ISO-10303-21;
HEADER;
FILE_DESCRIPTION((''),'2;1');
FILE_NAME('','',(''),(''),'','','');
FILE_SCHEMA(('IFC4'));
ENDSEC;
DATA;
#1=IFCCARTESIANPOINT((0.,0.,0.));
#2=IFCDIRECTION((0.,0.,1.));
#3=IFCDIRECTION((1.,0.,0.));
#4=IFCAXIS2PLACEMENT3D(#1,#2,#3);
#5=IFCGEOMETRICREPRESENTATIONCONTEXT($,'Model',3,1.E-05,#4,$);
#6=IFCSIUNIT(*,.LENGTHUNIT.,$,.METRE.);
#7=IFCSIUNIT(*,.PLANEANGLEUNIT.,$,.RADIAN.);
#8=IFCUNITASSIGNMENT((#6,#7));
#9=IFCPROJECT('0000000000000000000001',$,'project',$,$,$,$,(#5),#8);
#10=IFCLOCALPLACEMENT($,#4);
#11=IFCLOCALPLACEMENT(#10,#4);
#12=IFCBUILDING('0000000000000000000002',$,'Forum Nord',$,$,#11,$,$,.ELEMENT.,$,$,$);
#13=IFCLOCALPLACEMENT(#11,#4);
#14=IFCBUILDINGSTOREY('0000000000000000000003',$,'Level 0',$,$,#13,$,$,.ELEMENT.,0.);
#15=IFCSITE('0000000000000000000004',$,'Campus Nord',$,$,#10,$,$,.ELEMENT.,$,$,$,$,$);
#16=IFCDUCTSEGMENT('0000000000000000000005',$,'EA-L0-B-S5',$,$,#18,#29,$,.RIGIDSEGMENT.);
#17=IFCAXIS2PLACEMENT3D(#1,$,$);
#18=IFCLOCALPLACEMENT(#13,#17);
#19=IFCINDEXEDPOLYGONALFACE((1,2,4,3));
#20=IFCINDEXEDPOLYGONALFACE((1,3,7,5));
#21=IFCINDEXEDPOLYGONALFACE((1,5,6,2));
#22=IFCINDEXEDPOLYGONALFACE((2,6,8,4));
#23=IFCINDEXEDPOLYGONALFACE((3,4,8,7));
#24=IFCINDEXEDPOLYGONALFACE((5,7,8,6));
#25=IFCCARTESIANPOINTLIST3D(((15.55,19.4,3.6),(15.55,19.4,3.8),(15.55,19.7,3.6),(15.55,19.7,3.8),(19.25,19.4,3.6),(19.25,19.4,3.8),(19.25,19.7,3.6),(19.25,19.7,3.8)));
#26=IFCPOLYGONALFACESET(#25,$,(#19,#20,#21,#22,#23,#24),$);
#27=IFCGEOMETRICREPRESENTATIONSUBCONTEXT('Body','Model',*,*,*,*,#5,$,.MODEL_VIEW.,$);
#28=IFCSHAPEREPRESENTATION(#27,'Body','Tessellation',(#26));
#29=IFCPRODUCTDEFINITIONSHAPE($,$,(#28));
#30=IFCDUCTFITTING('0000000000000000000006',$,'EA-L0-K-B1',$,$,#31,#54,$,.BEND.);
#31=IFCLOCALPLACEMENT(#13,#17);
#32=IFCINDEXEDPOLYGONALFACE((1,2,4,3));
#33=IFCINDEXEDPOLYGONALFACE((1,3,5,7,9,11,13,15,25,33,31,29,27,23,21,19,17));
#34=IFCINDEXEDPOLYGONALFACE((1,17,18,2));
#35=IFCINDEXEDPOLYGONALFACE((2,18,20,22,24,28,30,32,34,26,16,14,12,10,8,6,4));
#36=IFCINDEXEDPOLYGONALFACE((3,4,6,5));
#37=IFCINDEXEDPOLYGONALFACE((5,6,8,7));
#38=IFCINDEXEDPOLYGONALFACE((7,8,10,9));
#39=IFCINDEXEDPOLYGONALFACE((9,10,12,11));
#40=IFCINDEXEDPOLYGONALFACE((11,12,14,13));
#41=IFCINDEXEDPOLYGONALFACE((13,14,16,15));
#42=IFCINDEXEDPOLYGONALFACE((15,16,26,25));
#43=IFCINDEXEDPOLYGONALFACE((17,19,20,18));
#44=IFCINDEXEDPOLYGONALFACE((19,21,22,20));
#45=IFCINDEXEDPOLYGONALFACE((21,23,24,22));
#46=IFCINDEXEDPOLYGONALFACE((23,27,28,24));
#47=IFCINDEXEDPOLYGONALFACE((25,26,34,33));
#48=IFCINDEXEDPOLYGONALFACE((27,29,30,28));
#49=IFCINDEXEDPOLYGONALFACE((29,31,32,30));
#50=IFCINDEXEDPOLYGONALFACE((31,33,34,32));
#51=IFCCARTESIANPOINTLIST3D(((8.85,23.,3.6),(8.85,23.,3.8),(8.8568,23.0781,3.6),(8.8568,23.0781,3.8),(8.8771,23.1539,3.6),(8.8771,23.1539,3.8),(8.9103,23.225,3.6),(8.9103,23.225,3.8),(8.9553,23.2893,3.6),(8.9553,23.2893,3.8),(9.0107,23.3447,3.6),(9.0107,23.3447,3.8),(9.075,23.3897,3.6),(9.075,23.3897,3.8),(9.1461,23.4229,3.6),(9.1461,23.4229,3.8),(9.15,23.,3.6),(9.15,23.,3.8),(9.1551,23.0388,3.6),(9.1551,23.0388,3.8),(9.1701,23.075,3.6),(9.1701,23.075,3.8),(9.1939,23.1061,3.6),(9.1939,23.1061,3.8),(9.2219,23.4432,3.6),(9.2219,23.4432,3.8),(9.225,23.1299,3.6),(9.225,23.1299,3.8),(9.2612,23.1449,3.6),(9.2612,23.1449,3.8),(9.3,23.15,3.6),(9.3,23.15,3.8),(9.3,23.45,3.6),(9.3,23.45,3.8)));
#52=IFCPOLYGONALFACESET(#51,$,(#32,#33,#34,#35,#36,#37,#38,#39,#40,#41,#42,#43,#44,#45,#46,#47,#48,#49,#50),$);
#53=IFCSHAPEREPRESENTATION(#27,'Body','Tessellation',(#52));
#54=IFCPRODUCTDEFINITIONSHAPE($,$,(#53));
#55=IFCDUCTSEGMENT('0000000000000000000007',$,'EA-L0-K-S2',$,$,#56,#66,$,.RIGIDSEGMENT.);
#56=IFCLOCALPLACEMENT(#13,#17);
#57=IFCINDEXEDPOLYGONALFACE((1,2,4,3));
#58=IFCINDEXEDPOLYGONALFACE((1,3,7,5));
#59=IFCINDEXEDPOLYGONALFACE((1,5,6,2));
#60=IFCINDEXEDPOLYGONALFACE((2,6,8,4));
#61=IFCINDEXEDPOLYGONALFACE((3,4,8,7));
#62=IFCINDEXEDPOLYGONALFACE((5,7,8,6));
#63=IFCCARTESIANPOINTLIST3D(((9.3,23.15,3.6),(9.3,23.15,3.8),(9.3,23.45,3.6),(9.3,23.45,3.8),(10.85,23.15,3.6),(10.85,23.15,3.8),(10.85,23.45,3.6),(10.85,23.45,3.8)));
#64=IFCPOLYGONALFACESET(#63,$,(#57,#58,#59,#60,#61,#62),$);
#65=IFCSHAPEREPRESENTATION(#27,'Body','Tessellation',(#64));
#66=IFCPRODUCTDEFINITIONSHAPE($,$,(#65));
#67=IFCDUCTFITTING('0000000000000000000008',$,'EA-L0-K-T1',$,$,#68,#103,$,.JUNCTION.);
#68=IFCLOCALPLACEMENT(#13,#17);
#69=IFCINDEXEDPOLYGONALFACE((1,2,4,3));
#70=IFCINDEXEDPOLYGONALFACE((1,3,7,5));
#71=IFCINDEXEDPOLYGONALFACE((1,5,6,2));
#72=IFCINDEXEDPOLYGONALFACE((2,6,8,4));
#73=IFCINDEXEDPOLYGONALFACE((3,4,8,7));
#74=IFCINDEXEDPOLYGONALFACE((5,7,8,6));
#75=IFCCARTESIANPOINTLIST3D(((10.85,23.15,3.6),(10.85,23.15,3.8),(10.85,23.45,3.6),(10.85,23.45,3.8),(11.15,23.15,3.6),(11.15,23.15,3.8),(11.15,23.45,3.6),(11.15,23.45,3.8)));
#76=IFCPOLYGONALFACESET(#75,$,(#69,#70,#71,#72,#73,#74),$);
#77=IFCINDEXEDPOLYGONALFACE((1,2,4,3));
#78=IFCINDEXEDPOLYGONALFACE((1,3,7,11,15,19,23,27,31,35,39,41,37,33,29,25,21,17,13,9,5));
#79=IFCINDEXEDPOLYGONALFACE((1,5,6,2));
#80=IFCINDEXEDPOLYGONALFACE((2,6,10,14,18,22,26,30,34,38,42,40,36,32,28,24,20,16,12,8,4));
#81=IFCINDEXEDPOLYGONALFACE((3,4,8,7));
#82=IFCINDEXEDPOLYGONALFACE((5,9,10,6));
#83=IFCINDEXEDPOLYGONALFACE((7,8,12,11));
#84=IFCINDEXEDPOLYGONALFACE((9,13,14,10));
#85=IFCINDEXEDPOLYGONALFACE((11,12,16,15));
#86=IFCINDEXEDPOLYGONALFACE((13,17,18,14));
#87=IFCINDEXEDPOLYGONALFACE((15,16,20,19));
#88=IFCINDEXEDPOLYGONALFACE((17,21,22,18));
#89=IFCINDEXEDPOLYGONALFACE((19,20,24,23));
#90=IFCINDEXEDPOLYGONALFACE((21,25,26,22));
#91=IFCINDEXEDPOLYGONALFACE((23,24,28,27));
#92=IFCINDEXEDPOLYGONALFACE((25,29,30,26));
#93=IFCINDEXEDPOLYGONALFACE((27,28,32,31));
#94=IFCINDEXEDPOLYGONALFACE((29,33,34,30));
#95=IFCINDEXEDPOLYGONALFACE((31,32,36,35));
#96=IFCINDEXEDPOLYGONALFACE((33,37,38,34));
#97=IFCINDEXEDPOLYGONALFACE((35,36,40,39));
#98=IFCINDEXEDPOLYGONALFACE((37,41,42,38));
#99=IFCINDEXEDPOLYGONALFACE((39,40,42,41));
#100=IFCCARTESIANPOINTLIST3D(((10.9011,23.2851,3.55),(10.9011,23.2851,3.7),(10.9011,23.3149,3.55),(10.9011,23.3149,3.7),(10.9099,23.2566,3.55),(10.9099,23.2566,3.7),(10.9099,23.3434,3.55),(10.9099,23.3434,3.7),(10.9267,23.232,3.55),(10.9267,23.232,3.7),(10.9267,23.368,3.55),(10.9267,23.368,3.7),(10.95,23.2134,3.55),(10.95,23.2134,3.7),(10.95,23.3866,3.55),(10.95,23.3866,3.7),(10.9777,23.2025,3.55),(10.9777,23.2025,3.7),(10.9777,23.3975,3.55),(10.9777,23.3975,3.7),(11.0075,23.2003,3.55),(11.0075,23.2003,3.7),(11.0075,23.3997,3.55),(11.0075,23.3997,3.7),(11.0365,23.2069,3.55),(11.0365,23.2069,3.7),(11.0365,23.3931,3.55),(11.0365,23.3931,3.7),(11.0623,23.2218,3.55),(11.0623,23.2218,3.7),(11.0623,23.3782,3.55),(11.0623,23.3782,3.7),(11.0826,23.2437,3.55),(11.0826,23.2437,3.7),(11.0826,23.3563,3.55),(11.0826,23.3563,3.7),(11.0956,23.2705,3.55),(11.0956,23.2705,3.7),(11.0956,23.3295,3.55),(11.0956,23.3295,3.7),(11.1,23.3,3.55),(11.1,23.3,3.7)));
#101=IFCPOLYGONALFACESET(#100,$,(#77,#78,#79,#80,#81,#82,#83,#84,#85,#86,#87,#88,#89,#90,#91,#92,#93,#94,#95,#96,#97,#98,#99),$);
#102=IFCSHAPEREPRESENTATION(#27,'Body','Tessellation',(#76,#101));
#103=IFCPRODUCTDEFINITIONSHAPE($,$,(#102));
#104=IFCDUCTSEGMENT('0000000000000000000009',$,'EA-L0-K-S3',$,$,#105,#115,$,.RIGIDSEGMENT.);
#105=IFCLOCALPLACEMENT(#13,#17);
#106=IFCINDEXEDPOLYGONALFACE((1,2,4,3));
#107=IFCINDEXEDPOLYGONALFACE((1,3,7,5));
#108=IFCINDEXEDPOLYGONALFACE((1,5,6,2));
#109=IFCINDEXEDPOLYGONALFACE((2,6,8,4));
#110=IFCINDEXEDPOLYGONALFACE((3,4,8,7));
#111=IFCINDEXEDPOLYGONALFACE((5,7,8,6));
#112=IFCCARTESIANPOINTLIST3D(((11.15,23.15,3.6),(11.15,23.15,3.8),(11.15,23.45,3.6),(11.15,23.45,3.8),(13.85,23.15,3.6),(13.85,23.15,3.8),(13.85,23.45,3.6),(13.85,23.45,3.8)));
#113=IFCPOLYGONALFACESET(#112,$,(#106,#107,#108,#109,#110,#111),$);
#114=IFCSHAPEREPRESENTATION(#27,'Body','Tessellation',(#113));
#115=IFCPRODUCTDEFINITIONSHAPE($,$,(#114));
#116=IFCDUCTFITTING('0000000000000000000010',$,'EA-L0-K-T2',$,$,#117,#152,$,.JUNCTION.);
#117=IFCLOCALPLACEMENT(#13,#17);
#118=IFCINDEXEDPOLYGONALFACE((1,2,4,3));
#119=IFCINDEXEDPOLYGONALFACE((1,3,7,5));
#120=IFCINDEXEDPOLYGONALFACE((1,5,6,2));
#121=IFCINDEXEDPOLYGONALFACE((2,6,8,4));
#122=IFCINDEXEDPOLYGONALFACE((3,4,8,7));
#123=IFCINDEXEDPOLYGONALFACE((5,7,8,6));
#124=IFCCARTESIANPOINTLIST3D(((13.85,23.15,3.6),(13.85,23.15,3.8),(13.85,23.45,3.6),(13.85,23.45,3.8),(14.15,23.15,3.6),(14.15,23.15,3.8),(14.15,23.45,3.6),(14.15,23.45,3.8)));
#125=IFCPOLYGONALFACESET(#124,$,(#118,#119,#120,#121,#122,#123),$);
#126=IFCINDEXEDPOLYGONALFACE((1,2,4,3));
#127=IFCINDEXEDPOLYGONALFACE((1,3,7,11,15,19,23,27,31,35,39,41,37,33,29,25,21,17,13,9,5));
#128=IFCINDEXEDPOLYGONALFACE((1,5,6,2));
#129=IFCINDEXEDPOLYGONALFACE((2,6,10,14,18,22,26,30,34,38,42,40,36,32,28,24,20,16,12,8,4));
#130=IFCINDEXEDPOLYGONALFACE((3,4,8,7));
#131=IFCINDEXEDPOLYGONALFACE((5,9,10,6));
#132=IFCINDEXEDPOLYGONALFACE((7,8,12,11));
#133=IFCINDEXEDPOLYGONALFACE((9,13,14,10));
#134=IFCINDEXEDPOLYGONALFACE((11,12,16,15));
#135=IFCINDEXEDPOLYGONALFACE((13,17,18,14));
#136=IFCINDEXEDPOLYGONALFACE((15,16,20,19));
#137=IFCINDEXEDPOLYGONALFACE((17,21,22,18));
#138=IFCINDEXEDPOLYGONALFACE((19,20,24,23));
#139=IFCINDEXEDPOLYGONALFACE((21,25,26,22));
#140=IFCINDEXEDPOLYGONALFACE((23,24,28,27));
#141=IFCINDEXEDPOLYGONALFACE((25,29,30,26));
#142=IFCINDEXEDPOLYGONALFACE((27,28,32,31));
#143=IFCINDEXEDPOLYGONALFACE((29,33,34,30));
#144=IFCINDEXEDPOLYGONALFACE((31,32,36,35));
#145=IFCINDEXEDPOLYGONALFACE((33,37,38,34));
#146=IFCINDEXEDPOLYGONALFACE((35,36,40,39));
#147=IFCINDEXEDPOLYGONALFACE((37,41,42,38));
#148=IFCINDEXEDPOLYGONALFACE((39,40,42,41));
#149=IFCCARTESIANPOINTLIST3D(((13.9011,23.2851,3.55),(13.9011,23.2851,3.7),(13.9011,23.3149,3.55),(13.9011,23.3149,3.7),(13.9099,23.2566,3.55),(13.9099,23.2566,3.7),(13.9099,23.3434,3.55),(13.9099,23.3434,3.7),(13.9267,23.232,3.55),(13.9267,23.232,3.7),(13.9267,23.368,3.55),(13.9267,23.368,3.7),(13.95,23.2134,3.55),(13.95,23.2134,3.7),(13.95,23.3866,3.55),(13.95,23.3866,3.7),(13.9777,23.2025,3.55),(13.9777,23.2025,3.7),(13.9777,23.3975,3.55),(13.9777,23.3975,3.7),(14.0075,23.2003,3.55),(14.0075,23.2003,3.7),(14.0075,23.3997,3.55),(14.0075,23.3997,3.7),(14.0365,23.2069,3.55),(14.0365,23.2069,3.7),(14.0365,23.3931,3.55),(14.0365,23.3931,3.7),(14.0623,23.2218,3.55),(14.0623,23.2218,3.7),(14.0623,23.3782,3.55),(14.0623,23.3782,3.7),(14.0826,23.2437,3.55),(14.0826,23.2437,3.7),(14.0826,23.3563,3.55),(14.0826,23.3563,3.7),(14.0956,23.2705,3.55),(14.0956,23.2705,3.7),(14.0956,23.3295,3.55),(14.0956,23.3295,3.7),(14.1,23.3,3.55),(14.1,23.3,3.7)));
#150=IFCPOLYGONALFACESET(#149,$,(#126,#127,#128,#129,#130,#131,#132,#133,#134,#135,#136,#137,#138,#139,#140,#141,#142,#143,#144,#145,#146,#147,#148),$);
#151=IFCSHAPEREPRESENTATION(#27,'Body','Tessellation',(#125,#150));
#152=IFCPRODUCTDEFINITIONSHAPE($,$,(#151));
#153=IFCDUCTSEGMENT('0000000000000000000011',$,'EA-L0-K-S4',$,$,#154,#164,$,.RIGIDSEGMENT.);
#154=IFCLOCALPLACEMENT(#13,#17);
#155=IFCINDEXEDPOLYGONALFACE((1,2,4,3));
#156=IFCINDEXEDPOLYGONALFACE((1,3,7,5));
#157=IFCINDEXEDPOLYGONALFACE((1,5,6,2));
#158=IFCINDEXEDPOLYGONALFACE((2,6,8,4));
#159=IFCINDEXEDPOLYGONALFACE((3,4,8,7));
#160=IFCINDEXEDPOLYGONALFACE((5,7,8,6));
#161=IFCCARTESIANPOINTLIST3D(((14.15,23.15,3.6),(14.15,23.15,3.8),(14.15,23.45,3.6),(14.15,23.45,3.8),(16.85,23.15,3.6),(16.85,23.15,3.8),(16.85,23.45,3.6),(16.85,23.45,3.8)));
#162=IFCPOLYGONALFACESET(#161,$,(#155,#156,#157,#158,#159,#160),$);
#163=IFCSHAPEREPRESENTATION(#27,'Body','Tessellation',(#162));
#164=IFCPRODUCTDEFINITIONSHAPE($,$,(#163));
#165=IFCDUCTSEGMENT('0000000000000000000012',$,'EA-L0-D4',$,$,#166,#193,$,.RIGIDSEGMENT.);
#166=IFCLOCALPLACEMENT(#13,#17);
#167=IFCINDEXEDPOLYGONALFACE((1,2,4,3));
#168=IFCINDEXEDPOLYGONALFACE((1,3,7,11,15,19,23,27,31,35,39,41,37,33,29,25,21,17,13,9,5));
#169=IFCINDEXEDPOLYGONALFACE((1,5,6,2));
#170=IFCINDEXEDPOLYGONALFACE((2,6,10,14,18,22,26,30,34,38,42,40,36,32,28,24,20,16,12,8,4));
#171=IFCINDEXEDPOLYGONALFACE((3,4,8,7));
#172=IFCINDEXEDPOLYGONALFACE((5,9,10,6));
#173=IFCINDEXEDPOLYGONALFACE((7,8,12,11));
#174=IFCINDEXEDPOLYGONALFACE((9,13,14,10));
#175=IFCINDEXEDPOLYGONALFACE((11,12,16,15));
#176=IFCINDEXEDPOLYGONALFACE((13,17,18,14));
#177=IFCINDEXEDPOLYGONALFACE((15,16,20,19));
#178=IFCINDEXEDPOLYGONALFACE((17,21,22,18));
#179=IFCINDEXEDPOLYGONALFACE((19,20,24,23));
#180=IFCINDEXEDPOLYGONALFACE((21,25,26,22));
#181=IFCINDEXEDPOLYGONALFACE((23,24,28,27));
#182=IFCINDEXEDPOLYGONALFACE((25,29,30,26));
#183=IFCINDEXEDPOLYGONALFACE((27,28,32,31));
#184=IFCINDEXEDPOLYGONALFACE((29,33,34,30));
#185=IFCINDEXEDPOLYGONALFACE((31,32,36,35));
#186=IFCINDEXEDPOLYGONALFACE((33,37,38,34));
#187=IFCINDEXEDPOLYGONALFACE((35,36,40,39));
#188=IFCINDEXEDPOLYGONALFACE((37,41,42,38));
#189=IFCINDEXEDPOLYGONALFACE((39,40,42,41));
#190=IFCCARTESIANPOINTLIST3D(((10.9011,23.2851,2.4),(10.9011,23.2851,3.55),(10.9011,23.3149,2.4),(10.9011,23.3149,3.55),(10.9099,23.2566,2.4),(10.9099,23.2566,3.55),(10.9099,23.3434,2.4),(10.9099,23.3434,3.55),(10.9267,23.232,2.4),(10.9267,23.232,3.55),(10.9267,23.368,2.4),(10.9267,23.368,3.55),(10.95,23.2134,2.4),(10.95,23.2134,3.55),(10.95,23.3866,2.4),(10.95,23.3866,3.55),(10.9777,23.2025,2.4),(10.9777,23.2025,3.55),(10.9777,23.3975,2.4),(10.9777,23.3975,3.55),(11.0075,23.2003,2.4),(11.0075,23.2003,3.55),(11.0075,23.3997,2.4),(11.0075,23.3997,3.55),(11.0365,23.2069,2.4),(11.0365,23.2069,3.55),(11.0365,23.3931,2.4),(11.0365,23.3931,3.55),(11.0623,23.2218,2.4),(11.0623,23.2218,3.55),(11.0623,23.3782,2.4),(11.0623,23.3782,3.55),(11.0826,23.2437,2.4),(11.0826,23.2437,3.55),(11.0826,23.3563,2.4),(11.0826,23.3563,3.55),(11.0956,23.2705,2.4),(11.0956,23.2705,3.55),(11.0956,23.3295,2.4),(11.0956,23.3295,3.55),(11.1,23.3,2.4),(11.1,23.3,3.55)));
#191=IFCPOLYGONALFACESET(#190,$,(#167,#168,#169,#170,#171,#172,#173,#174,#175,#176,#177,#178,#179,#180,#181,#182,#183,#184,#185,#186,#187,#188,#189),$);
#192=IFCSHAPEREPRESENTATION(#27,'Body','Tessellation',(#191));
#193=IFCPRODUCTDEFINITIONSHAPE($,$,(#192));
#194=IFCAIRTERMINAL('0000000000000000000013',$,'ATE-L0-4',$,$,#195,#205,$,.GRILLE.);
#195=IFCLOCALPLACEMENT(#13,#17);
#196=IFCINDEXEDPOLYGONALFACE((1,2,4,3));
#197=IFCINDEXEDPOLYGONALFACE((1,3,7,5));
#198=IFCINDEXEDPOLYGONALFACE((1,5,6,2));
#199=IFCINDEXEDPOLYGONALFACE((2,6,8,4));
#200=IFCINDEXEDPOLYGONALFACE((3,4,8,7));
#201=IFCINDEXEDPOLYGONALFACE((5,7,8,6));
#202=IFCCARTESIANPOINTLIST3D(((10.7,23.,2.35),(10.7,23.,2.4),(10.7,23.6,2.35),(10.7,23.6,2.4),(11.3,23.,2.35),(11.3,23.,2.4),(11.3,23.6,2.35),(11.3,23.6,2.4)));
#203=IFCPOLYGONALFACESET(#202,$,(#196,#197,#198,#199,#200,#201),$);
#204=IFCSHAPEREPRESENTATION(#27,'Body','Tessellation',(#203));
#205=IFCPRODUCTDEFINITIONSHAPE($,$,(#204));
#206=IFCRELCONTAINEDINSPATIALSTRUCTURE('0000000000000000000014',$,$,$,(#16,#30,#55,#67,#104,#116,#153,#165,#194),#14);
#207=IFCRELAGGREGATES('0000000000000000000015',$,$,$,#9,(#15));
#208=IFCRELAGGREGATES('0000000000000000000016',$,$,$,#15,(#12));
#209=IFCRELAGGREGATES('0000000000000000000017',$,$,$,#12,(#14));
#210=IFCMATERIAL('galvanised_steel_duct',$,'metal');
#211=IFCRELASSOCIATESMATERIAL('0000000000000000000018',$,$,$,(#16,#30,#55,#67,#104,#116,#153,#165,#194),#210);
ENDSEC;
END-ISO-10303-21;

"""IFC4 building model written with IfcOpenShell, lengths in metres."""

from ifc_helpers import new_model, entity, si_unit, frame, origin_with_axes, origin_2d_with_axis, place, context, subcontext, project, spatial, rectangle, circle, extrude, material, element, save


model = new_model("IFC4")

# Units and contexts
model_context = context("Model", 3, precision=1e-05, world=origin_with_axes())
body_context = subcontext(model_context, "Body", "Model", "MODEL_VIEW")
ifc_project = project(units=[si_unit("LENGTHUNIT", "METRE"), si_unit("PLANEANGLEUNIT", "RADIAN")], contexts=[model_context])

# Site, building, storey
site_placement = place(None, origin_with_axes())
site = spatial("IfcSite", under=ifc_project, at=site_placement, Name="Campus Nord", CompositionType="ELEMENT")
building_placement = place(site_placement, origin_with_axes())
building = spatial("IfcBuilding", under=site, at=building_placement, Name="Forum Nord", CompositionType="ELEMENT")
storey_placement = place(building_placement, origin_with_axes())
storey = spatial("IfcBuildingStorey", under=building, at=storey_placement, Name="Level 0", CompositionType="ELEMENT", Elevation=0.0)

# Duct segment
ifc_material_1 = material(Name="galvanised_steel_duct", Category="metal")
duct_segment_1_placement = place(storey_placement, frame((15.55, 19.55, 3.7), z_axis=(1.0, 0.0, 0.0), x_axis=(0.0, 1.0, 0.0)))
element("IfcDuctSegment", 1, at=duct_segment_1_placement, inside=storey, material=ifc_material_1, Name="EA-L0-B-S5", PredefinedType="RIGIDSEGMENT", context=body_context, shape_type="SweptSolid", body=[
    extrude(rectangle(XDim=0.3, YDim=0.2, at=origin_2d_with_axis()), origin_with_axes(), (0.0, 0.0, 1.0), 3.7),
])

# Duct fitting
duct_fitting_1_placement = place(storey_placement, frame((9.0, 23.0, 3.7), z_axis=(0.0, 1.0, 0.0), x_axis=(-1.0, 0.0, 0.0)))
element("IfcDuctFitting", 2, at=duct_fitting_1_placement, inside=storey, material=ifc_material_1, Name="EA-L0-K-B1", PredefinedType="BEND", context=body_context, shape_type="SweptSolid", body=[
    entity("IfcRevolvedAreaSolid", entity("IfcRectangleProfileDef", "AREA", None, entity("IfcAxis2Placement2D", entity("IfcCartesianPoint", [0.0, 0.0]), entity("IfcDirection", [1.0, 0.0])), 0.3, 0.2), entity("IfcAxis2Placement3D", entity("IfcCartesianPoint", [0.0, 0.0, 0.0]), entity("IfcDirection", [0.0, 0.0, 1.0]), entity("IfcDirection", [1.0, 0.0, 0.0])), entity("IfcAxis1Placement", entity("IfcCartesianPoint", [-0.3, 0.0, 0.0]), entity("IfcDirection", [0.0, -1.0, 0.0])), 1.5708),
])

# Duct segment
duct_segment_2_placement = place(storey_placement, frame((9.3, 23.3, 3.7), z_axis=(1.0, 0.0, 0.0), x_axis=(0.0, 1.0, 0.0)))
element("IfcDuctSegment", 3, at=duct_segment_2_placement, inside=storey, material=ifc_material_1, Name="EA-L0-K-S2", PredefinedType="RIGIDSEGMENT", context=body_context, shape_type="SweptSolid", body=[
    extrude(rectangle(XDim=0.3, YDim=0.2, at=origin_2d_with_axis()), origin_with_axes(), (0.0, 0.0, 1.0), 1.55),
])

# Duct fitting
duct_fitting_2_placement = place(storey_placement, frame((10.85, 23.3, 3.7), z_axis=(1.0, 0.0, 0.0), x_axis=(0.0, 1.0, 0.0)))
element("IfcDuctFitting", 4, at=duct_fitting_2_placement, inside=storey, material=ifc_material_1, Name="EA-L0-K-T1", PredefinedType="JUNCTION", context=body_context, shape_type="SweptSolid", body=[
    extrude(rectangle(XDim=0.3, YDim=0.2, at=origin_2d_with_axis()), origin_with_axes(), (0.0, 0.0, 1.0), 0.3),
    extrude(circle(Radius=0.1, at=origin_2d_with_axis()), frame((0.0, 0.0, 0.15), z_axis=(0.0, -1.0, 0.0), x_axis=(0.0, 0.0, 1.0)), (0.0, 0.0, 1.0), 0.15),
])

# Duct segment
duct_segment_3_placement = place(storey_placement, frame((11.15, 23.3, 3.7), z_axis=(1.0, 0.0, 0.0), x_axis=(0.0, 1.0, 0.0)))
element("IfcDuctSegment", 5, at=duct_segment_3_placement, inside=storey, material=ifc_material_1, Name="EA-L0-K-S3", PredefinedType="RIGIDSEGMENT", context=body_context, shape_type="SweptSolid", body=[
    extrude(rectangle(XDim=0.3, YDim=0.2, at=origin_2d_with_axis()), origin_with_axes(), (0.0, 0.0, 1.0), 2.7),
])

# Duct fitting
duct_fitting_3_placement = place(storey_placement, frame((13.85, 23.3, 3.7), z_axis=(1.0, 0.0, 0.0), x_axis=(0.0, 1.0, 0.0)))
element("IfcDuctFitting", 6, at=duct_fitting_3_placement, inside=storey, material=ifc_material_1, Name="EA-L0-K-T2", PredefinedType="JUNCTION", context=body_context, shape_type="SweptSolid", body=[
    extrude(rectangle(XDim=0.3, YDim=0.2, at=origin_2d_with_axis()), origin_with_axes(), (0.0, 0.0, 1.0), 0.3),
    extrude(circle(Radius=0.1, at=origin_2d_with_axis()), frame((0.0, 0.0, 0.15), z_axis=(0.0, -1.0, 0.0), x_axis=(0.0, 0.0, 1.0)), (0.0, 0.0, 1.0), 0.15),
])

# Duct segments
duct_segment_4_placement = place(storey_placement, frame((14.15, 23.3, 3.7), z_axis=(1.0, 0.0, 0.0), x_axis=(0.0, 1.0, 0.0)))
element("IfcDuctSegment", 7, at=duct_segment_4_placement, inside=storey, material=ifc_material_1, Name="EA-L0-K-S4", PredefinedType="RIGIDSEGMENT", context=body_context, shape_type="SweptSolid", body=[
    extrude(rectangle(XDim=0.3, YDim=0.2, at=origin_2d_with_axis()), origin_with_axes(), (0.0, 0.0, 1.0), 2.7),
])
duct_segment_5_placement = place(storey_placement, frame((11.0, 23.3, 3.55), z_axis=(0.0, 0.0, -1.0), x_axis=(1.0, 0.0, 0.0)))
element("IfcDuctSegment", 8, at=duct_segment_5_placement, inside=storey, material=ifc_material_1, Name="EA-L0-D4", PredefinedType="RIGIDSEGMENT", context=body_context, shape_type="SweptSolid", body=[
    extrude(circle(Radius=0.1, at=origin_2d_with_axis()), origin_with_axes(), (0.0, 0.0, 1.0), 1.15),
])

# Air terminal
air_terminal_1_placement = place(storey_placement, frame((11.0, 23.3, 2.35), z_axis=(0.0, 0.0, 1.0), x_axis=(1.0, 0.0, 0.0)))
element("IfcAirTerminal", 9, at=air_terminal_1_placement, inside=storey, material=ifc_material_1, Name="ATE-L0-4", PredefinedType="GRILLE", context=body_context, shape_type="SweptSolid", body=[
    extrude(rectangle(XDim=0.6, YDim=0.6, at=origin_2d_with_axis()), origin_with_axes(), (0.0, 0.0, 1.0), 0.05),
])

save(model, "model.ifc")
